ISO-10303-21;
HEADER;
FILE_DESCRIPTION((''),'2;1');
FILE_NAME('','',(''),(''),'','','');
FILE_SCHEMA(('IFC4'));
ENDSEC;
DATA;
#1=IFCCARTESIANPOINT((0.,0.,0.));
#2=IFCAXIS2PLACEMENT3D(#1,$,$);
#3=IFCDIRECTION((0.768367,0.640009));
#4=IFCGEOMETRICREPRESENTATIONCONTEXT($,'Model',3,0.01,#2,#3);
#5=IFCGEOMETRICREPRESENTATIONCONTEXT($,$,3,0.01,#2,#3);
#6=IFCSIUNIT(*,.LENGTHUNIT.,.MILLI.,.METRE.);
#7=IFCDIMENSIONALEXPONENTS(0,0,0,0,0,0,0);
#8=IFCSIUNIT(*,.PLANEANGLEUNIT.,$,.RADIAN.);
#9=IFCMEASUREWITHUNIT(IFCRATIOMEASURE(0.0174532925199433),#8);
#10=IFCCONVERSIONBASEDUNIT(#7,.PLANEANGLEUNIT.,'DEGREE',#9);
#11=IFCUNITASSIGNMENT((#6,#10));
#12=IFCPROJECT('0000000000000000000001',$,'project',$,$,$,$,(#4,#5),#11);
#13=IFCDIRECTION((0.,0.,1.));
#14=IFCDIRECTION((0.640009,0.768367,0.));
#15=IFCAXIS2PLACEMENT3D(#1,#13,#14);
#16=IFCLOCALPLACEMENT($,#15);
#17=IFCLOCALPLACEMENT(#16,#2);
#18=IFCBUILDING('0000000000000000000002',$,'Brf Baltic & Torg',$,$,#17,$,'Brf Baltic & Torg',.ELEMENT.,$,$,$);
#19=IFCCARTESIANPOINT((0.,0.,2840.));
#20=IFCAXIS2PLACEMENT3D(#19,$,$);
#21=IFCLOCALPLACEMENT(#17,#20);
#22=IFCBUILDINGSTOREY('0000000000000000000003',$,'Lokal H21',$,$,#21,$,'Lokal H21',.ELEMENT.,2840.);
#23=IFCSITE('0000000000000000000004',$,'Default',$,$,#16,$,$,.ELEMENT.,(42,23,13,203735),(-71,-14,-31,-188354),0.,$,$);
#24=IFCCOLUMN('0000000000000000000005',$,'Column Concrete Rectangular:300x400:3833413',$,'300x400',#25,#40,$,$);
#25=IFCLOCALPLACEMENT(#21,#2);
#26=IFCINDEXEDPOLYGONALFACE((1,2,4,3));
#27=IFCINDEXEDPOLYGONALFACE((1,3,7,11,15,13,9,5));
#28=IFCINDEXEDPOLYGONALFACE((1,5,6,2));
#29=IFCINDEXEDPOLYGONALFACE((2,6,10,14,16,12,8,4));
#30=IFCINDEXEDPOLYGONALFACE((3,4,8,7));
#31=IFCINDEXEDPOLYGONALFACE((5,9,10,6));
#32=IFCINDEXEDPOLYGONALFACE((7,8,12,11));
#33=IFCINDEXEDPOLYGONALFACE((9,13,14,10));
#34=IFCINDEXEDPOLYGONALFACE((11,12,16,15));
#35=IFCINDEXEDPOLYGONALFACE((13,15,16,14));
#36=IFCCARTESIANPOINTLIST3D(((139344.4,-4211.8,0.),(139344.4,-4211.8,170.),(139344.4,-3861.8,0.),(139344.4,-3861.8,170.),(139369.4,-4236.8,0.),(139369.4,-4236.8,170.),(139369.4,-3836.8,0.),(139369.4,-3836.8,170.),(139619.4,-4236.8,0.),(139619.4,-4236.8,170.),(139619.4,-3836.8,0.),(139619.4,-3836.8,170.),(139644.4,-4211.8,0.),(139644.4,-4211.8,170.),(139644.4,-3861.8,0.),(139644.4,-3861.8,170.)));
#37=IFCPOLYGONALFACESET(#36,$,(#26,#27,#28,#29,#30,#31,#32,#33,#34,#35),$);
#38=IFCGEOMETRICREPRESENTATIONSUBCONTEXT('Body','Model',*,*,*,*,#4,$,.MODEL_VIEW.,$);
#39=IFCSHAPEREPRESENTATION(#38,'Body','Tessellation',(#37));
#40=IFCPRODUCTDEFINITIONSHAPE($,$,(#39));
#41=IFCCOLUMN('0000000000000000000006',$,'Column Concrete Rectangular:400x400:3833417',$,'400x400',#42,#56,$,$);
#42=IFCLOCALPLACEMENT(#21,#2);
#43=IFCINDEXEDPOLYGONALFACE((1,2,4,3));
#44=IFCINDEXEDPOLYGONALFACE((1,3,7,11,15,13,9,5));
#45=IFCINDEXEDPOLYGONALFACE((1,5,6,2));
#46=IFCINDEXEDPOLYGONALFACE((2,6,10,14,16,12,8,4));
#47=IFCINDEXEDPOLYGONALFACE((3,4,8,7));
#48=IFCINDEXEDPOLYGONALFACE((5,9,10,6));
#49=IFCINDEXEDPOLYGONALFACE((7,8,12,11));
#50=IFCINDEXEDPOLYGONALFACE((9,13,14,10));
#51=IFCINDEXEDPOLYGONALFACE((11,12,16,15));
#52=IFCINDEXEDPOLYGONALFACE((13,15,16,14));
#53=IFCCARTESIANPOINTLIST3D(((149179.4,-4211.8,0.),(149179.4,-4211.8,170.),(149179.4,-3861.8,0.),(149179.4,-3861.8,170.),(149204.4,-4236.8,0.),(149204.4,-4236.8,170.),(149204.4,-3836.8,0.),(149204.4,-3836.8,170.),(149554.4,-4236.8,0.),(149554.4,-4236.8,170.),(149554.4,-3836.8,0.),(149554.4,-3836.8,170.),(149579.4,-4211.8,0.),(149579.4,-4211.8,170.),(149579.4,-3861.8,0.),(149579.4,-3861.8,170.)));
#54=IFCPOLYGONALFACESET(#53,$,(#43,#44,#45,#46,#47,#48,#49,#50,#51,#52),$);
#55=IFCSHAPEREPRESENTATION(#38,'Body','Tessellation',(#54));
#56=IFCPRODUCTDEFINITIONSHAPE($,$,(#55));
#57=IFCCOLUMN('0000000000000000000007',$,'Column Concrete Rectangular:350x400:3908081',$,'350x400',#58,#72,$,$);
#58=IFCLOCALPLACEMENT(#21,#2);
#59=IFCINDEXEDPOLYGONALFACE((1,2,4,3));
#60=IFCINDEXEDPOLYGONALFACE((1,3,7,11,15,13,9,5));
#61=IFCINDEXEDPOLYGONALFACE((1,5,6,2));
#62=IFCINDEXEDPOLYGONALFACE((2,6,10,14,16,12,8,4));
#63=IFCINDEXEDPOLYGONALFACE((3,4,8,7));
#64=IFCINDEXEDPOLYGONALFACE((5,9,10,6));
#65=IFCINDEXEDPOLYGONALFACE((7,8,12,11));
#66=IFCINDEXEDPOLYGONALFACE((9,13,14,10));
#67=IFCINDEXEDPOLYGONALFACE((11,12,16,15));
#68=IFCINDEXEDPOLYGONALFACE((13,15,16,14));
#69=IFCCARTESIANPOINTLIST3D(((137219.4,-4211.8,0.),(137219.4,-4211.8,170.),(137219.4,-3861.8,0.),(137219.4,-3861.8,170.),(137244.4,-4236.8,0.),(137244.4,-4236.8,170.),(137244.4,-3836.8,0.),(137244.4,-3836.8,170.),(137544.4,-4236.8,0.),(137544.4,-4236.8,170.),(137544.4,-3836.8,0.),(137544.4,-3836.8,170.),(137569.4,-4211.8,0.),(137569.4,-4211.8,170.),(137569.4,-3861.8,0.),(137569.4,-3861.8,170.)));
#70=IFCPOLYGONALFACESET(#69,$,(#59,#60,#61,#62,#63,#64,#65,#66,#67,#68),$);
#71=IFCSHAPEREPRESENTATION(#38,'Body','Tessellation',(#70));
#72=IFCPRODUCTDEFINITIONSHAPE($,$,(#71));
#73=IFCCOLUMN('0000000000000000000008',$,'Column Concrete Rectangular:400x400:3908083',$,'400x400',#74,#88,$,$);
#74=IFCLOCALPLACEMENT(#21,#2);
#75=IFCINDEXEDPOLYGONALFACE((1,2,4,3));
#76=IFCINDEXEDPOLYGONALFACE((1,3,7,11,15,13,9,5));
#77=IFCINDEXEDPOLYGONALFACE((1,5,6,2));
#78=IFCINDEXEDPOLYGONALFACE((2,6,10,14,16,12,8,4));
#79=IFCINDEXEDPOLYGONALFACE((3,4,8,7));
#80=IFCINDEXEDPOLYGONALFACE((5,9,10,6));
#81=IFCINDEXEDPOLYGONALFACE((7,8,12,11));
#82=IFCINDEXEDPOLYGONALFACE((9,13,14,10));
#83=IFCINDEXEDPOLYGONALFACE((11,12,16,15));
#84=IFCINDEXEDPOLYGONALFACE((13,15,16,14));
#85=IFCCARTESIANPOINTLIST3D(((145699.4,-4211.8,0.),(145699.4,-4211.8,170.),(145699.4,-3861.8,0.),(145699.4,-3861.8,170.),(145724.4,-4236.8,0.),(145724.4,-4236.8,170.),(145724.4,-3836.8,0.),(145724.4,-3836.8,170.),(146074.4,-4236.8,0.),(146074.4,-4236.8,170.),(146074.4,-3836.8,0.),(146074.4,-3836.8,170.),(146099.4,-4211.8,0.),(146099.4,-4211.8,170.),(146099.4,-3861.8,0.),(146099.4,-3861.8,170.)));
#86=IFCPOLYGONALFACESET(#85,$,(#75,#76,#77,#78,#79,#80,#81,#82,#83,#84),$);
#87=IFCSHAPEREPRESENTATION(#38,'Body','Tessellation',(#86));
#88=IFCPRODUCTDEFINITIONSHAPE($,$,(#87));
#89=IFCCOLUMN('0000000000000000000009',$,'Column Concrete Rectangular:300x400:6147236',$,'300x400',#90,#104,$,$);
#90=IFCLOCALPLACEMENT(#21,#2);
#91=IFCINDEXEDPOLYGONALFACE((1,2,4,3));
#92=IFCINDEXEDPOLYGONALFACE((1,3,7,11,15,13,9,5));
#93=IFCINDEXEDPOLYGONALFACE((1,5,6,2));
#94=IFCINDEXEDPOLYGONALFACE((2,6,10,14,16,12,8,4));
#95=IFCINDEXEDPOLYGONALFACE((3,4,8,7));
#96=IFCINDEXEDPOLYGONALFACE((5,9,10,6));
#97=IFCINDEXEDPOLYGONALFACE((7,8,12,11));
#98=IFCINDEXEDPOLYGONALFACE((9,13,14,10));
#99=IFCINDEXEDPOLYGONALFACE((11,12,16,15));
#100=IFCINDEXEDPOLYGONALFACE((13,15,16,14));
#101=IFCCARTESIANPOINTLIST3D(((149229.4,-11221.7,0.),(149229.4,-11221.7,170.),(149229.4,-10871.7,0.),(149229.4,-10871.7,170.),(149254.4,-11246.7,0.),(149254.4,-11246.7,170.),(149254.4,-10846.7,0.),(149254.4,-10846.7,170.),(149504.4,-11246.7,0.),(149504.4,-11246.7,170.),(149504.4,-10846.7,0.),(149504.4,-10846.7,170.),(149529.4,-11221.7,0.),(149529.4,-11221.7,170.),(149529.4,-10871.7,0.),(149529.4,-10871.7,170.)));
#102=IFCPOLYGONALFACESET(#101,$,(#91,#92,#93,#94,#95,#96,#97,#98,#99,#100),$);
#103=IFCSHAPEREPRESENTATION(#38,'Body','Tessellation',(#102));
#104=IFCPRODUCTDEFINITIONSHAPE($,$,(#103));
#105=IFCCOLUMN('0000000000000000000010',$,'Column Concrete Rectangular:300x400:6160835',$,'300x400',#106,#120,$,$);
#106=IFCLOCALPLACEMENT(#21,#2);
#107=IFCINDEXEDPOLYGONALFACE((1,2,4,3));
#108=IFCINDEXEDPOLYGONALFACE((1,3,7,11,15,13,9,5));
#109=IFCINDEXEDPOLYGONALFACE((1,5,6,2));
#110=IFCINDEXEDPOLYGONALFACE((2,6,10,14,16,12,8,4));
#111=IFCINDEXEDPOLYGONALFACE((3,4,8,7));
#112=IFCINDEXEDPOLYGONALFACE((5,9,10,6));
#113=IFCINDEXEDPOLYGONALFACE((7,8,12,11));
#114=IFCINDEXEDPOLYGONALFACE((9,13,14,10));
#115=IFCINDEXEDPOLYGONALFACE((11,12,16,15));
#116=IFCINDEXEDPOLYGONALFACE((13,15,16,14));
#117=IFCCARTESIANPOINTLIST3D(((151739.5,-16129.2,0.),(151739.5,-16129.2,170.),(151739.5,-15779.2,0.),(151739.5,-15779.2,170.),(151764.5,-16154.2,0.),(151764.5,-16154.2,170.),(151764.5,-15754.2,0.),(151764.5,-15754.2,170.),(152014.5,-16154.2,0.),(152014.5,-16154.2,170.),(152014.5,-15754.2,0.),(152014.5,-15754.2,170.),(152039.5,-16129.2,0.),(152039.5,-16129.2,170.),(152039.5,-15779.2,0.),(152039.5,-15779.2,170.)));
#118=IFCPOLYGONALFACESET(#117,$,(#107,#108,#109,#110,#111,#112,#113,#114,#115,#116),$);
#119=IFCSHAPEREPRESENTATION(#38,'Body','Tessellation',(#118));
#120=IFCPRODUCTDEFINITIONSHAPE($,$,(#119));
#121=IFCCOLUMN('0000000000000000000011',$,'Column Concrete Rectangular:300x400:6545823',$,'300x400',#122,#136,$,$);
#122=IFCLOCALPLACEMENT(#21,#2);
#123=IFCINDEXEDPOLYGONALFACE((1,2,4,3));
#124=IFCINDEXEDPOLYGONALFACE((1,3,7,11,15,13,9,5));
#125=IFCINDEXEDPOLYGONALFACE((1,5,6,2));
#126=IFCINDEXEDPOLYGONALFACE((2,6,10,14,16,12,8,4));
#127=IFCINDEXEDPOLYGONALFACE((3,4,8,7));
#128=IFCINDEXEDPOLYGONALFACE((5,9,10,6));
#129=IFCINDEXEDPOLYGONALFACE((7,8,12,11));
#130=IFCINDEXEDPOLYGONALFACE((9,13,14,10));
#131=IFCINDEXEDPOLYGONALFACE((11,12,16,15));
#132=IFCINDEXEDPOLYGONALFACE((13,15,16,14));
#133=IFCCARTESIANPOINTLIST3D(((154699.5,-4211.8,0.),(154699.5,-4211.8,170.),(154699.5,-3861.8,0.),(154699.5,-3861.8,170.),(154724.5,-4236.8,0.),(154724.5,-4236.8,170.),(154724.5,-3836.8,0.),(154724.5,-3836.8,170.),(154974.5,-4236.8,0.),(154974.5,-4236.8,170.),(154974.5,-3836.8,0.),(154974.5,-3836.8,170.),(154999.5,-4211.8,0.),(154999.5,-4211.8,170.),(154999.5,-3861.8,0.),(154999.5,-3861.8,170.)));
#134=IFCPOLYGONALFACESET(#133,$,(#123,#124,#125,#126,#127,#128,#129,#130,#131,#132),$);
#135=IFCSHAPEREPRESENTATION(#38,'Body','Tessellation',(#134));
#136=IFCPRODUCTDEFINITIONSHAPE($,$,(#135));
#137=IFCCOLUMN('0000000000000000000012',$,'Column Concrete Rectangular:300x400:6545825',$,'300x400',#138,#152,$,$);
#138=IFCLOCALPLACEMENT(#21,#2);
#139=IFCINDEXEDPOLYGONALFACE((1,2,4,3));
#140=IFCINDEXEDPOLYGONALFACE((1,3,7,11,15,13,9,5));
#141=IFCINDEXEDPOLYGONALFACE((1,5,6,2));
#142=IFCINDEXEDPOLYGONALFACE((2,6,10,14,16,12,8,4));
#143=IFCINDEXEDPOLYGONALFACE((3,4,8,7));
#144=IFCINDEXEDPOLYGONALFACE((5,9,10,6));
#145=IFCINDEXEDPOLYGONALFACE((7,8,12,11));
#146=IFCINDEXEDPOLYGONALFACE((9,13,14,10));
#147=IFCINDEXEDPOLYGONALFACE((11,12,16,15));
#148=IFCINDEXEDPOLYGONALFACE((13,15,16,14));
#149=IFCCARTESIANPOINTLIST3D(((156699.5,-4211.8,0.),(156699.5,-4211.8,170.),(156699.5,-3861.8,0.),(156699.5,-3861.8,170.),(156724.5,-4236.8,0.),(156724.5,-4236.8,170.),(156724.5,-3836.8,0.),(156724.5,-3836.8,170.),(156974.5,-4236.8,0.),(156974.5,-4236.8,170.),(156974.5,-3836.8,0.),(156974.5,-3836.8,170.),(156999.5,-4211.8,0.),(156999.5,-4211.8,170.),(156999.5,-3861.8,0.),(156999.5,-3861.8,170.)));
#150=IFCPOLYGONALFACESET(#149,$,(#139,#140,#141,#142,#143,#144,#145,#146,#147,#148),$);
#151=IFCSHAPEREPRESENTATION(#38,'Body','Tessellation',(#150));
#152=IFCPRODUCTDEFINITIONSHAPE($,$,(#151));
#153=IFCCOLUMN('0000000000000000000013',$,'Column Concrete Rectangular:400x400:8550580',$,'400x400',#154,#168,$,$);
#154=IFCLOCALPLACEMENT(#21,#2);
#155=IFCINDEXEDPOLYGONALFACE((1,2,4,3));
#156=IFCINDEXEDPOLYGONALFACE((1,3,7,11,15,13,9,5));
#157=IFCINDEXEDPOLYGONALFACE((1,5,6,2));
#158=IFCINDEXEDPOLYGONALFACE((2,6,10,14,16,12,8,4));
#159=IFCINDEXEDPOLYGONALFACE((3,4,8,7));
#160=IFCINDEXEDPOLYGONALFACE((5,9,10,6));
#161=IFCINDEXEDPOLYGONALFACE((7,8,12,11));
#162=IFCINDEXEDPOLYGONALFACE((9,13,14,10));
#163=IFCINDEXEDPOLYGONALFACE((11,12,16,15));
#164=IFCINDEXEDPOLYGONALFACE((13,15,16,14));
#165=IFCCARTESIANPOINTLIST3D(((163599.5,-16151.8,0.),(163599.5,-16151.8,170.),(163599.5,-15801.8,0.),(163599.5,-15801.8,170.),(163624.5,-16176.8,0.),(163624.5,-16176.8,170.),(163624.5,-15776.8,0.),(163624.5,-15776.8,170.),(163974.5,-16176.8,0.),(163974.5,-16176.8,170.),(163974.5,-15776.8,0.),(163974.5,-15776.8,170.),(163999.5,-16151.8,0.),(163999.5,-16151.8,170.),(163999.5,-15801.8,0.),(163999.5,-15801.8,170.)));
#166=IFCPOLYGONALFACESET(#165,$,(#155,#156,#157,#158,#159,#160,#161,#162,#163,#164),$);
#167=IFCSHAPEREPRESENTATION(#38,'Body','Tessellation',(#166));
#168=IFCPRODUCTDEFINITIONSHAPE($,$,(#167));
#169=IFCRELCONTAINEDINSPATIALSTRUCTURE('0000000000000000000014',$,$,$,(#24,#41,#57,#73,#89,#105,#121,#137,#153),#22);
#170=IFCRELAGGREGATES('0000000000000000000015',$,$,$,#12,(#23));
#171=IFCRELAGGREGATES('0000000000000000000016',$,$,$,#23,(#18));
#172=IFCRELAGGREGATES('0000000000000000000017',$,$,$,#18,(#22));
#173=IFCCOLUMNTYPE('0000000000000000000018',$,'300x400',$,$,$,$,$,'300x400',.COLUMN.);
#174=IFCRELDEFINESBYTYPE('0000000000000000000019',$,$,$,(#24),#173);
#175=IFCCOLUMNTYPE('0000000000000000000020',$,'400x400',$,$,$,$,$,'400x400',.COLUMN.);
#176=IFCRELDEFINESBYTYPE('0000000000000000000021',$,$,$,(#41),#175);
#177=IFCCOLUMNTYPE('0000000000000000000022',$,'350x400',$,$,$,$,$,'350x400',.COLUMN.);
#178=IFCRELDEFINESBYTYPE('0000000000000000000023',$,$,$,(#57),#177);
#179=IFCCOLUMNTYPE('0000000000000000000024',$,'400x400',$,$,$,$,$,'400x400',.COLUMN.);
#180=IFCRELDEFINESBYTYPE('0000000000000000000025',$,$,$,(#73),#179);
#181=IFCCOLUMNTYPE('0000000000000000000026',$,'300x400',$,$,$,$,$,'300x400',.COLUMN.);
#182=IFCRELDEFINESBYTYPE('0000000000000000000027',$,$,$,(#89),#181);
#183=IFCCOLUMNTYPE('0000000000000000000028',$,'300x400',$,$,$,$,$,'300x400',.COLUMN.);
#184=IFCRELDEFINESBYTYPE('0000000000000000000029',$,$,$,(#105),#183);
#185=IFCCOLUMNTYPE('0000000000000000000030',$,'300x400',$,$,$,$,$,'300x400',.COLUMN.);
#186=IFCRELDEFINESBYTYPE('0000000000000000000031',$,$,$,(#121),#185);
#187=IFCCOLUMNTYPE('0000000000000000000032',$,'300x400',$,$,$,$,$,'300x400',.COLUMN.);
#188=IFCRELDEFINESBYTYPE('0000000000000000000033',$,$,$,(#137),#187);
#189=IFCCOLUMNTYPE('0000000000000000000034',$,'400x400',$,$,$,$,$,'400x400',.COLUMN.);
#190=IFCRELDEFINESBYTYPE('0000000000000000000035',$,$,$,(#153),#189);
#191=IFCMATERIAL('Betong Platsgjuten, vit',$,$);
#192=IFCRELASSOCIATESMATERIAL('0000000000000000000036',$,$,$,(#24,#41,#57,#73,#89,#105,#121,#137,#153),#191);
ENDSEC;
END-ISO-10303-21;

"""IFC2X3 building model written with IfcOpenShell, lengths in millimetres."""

from ifc_helpers import new_model, entity, si_unit, converted_unit, direction, frame, origin, place, context, subcontext, project, spatial, polyline, outline, extrude, source, transform, mapped, material, type_object, type_shapes, element, save


model = new_model("IFC2X3")

# Units and contexts
model_context = context("Model", 3, precision=0.01, world=origin(), true_north=direction((0.768367, 0.640009)))
context_of_model = context(None, 3, precision=0.01, world=origin(), true_north=direction((0.768367, 0.640009)))
body_context = subcontext(model_context, "Body", "Model", "MODEL_VIEW")
ifc_project = project(units=[si_unit("LENGTHUNIT", "METRE", prefix="MILLI"), converted_unit("PLANEANGLEUNIT", "DEGREE", entity("IfcRatioMeasure", 0.0174532925199433), si_unit("PLANEANGLEUNIT", "RADIAN"), dimensions=[0, 0, 0, 0, 0, 0, 0])], contexts=[model_context, context_of_model])

# Site, building, storey
site_placement = place(None, frame((0.0, 0.0, 0.0), z_axis=(0.0, 0.0, 1.0), x_axis=(0.640009, 0.768367, 0.0)))
site = spatial("IfcSite", under=ifc_project, at=site_placement, Name="Default", CompositionType="ELEMENT", RefLatitude=(42, 23, 13, 203735), RefLongitude=(-71, -14, -31, -188354), RefElevation=0.0)
building_placement = place(site_placement, origin())
building = spatial("IfcBuilding", under=site, at=building_placement, Name="Brf Baltic & Torg", LongName="Brf Baltic & Torg", CompositionType="ELEMENT")
storey_placement = place(building_placement, frame((0.0, 0.0, 2840.0)))
storey = spatial("IfcBuildingStorey", under=building, at=storey_placement, Name="Lokal H21", LongName="Lokal H21", CompositionType="ELEMENT", Elevation=2840.0)

# Columns
ifc_material_1 = material(Name="Betong Platsgjuten, vit")
column_type_1 = type_object("IfcColumnType", Name="300x400", ElementType="300x400", PredefinedType="COLUMN")
shared_shape_1 = source(origin(), body_context, "Body", "SweptSolid", [
    extrude(outline(polyline([(-175.0, -150.0), (175.0, -150.0), (200.0, -125.0), (200.0, 125.0), (175.0, 150.0), (-175.0, 150.0), (-200.0, 125.0), (-200.0, -125.0), (-175.0, -150.0)])), frame((0.0, 0.0, 2840.0), z_axis=(0.0, 0.0, 1.0), x_axis=(0.0, -1.0, 0.0)), (0.0, 0.0, 1.0), 170.0),
])
type_shapes(column_type_1, [shared_shape_1])
column_1_placement = place(storey_placement, frame((139494.4, -4036.8, -2840.0)))
element("IfcColumn", 1, at=column_1_placement, inside=storey, type_object=column_type_1, material=ifc_material_1, Name="Column Concrete Rectangular:300x400:3833413", ObjectType="300x400", context=body_context, shape_type="MappedRepresentation", body=[
    mapped(shared_shape_1, transform((0.0, 0.0, 0.0), scale=1.0)),
])
column_type_2 = type_object("IfcColumnType", Name="400x400", ElementType="400x400", PredefinedType="COLUMN")
shared_shape_2 = source(origin(), body_context, "Body", "SweptSolid", [
    extrude(outline(polyline([(-175.0, -200.0), (175.0, -200.0), (200.0, -175.0), (200.0, 175.0), (175.0, 200.0), (-175.0, 200.0), (-200.0, 175.0), (-200.0, -175.0), (-175.0, -200.0)])), frame((0.0, 0.0, 2840.0), z_axis=(0.0, 0.0, 1.0), x_axis=(0.0, -1.0, 0.0)), (0.0, 0.0, 1.0), 170.0),
])
type_shapes(column_type_2, [shared_shape_2])
column_2_placement = place(storey_placement, frame((149379.4, -4036.8, -2840.0)))
element("IfcColumn", 2, at=column_2_placement, inside=storey, type_object=column_type_2, material=ifc_material_1, Name="Column Concrete Rectangular:400x400:3833417", ObjectType="400x400", context=body_context, shape_type="MappedRepresentation", body=[
    mapped(shared_shape_2, transform((0.0, 0.0, 0.0), scale=1.0)),
])
column_type_3 = type_object("IfcColumnType", Name="350x400", ElementType="350x400", PredefinedType="COLUMN")
shared_shape_3 = source(origin(), body_context, "Body", "SweptSolid", [
    extrude(outline(polyline([(-175.0, -175.0), (175.0, -175.0), (200.0, -150.0), (200.0, 150.0), (175.0, 175.0), (-175.0, 175.0), (-200.0, 150.0), (-200.0, -150.0), (-175.0, -175.0)])), frame((0.0, 0.0, 2840.0), z_axis=(0.0, 0.0, 1.0), x_axis=(0.0, -1.0, 0.0)), (0.0, 0.0, 1.0), 170.0),
])
type_shapes(column_type_3, [shared_shape_3])
column_3_placement = place(storey_placement, frame((137394.4, -4036.8, -2840.0)))
element("IfcColumn", 3, at=column_3_placement, inside=storey, type_object=column_type_3, material=ifc_material_1, Name="Column Concrete Rectangular:350x400:3908081", ObjectType="350x400", context=body_context, shape_type="MappedRepresentation", body=[
    mapped(shared_shape_3, transform((0.0, 0.0, 0.0), scale=1.0)),
])
column_type_4 = type_object("IfcColumnType", Name="400x400", ElementType="400x400", PredefinedType="COLUMN")
shared_shape_4 = source(origin(), body_context, "Body", "SweptSolid", [
    extrude(outline(polyline([(-175.0, -200.0), (175.0, -200.0), (200.0, -175.0), (200.0, 175.0), (175.0, 200.0), (-175.0, 200.0), (-200.0, 175.0), (-200.0, -175.0), (-175.0, -200.0)])), frame((0.0, 0.0, 2840.0), z_axis=(0.0, 0.0, 1.0), x_axis=(0.0, -1.0, 0.0)), (0.0, 0.0, 1.0), 170.0),
])
type_shapes(column_type_4, [shared_shape_4])
column_4_placement = place(storey_placement, frame((145899.4, -4036.8, -2840.0)))
element("IfcColumn", 4, at=column_4_placement, inside=storey, type_object=column_type_4, material=ifc_material_1, Name="Column Concrete Rectangular:400x400:3908083", ObjectType="400x400", context=body_context, shape_type="MappedRepresentation", body=[
    mapped(shared_shape_4, transform((0.0, 0.0, 0.0), scale=1.0)),
])
column_type_5 = type_object("IfcColumnType", Name="300x400", ElementType="300x400", PredefinedType="COLUMN")
shared_shape_5 = source(origin(), body_context, "Body", "SweptSolid", [
    extrude(outline(polyline([(-175.0, -150.0), (175.0, -150.0), (200.0, -125.0), (200.0, 125.0), (175.0, 150.0), (-175.0, 150.0), (-200.0, 125.0), (-200.0, -125.0), (-175.0, -150.0)])), frame((0.0, 0.0, 2840.0), z_axis=(0.0, 0.0, 1.0), x_axis=(0.0, -1.0, 0.0)), (0.0, 0.0, 1.0), 170.0),
])
type_shapes(column_type_5, [shared_shape_5])
column_5_placement = place(storey_placement, frame((149379.4, -11046.7, -2840.0)))
element("IfcColumn", 5, at=column_5_placement, inside=storey, type_object=column_type_5, material=ifc_material_1, Name="Column Concrete Rectangular:300x400:6147236", ObjectType="300x400", context=body_context, shape_type="MappedRepresentation", body=[
    mapped(shared_shape_5, transform((0.0, 0.0, 0.0), scale=1.0)),
])
column_type_6 = type_object("IfcColumnType", Name="300x400", ElementType="300x400", PredefinedType="COLUMN")
shared_shape_6 = source(origin(), body_context, "Body", "SweptSolid", [
    extrude(outline(polyline([(-175.0, -150.0), (175.0, -150.0), (200.0, -125.0), (200.0, 125.0), (175.0, 150.0), (-175.0, 150.0), (-200.0, 125.0), (-200.0, -125.0), (-175.0, -150.0)])), frame((0.0, 0.0, 2840.0), z_axis=(0.0, 0.0, 1.0), x_axis=(0.0, -1.0, 0.0)), (0.0, 0.0, 1.0), 170.0),
])
type_shapes(column_type_6, [shared_shape_6])
column_6_placement = place(storey_placement, frame((151889.5, -15954.2, -2840.0)))
element("IfcColumn", 6, at=column_6_placement, inside=storey, type_object=column_type_6, material=ifc_material_1, Name="Column Concrete Rectangular:300x400:6160835", ObjectType="300x400", context=body_context, shape_type="MappedRepresentation", body=[
    mapped(shared_shape_6, transform((0.0, 0.0, 0.0), scale=1.0)),
])
column_type_7 = type_object("IfcColumnType", Name="300x400", ElementType="300x400", PredefinedType="COLUMN")
shared_shape_7 = source(origin(), body_context, "Body", "SweptSolid", [
    extrude(outline(polyline([(-175.0, -150.0), (175.0, -150.0), (200.0, -125.0), (200.0, 125.0), (175.0, 150.0), (-175.0, 150.0), (-200.0, 125.0), (-200.0, -125.0), (-175.0, -150.0)])), frame((0.0, 0.0, 2840.0), z_axis=(0.0, 0.0, 1.0), x_axis=(0.0, -1.0, 0.0)), (0.0, 0.0, 1.0), 170.0),
])
type_shapes(column_type_7, [shared_shape_7])
column_7_placement = place(storey_placement, frame((154849.5, -4036.8, -2840.0)))
element("IfcColumn", 7, at=column_7_placement, inside=storey, type_object=column_type_7, material=ifc_material_1, Name="Column Concrete Rectangular:300x400:6545823", ObjectType="300x400", context=body_context, shape_type="MappedRepresentation", body=[
    mapped(shared_shape_7, transform((0.0, 0.0, 0.0), scale=1.0)),
])
column_type_8 = type_object("IfcColumnType", Name="300x400", ElementType="300x400", PredefinedType="COLUMN")
shared_shape_8 = source(origin(), body_context, "Body", "SweptSolid", [
    extrude(outline(polyline([(-175.0, -150.0), (175.0, -150.0), (200.0, -125.0), (200.0, 125.0), (175.0, 150.0), (-175.0, 150.0), (-200.0, 125.0), (-200.0, -125.0), (-175.0, -150.0)])), frame((0.0, 0.0, 2840.0), z_axis=(0.0, 0.0, 1.0), x_axis=(0.0, -1.0, 0.0)), (0.0, 0.0, 1.0), 170.0),
])
type_shapes(column_type_8, [shared_shape_8])
column_8_placement = place(storey_placement, frame((156849.5, -4036.8, -2840.0)))
element("IfcColumn", 8, at=column_8_placement, inside=storey, type_object=column_type_8, material=ifc_material_1, Name="Column Concrete Rectangular:300x400:6545825", ObjectType="300x400", context=body_context, shape_type="MappedRepresentation", body=[
    mapped(shared_shape_8, transform((0.0, 0.0, 0.0), scale=1.0)),
])
column_type_9 = type_object("IfcColumnType", Name="400x400", ElementType="400x400", PredefinedType="COLUMN")
shared_shape_9 = source(origin(), body_context, "Body", "SweptSolid", [
    extrude(outline(polyline([(-175.0, -200.0), (175.0, -200.0), (200.0, -175.0), (200.0, 175.0), (175.0, 200.0), (-175.0, 200.0), (-200.0, 175.0), (-200.0, -175.0), (-175.0, -200.0)])), frame((0.0, 0.0, 2840.0), z_axis=(0.0, 0.0, 1.0), x_axis=(0.0, -1.0, 0.0)), (0.0, 0.0, 1.0), 170.0),
])
type_shapes(column_type_9, [shared_shape_9])
column_9_placement = place(storey_placement, frame((163799.5, -15976.8, -2840.0)))
element("IfcColumn", 9, at=column_9_placement, inside=storey, type_object=column_type_9, material=ifc_material_1, Name="Column Concrete Rectangular:400x400:8550580", ObjectType="400x400", context=body_context, shape_type="MappedRepresentation", body=[
    mapped(shared_shape_9, transform((0.0, 0.0, 0.0), scale=1.0)),
])

save(model, "model.ifc")
